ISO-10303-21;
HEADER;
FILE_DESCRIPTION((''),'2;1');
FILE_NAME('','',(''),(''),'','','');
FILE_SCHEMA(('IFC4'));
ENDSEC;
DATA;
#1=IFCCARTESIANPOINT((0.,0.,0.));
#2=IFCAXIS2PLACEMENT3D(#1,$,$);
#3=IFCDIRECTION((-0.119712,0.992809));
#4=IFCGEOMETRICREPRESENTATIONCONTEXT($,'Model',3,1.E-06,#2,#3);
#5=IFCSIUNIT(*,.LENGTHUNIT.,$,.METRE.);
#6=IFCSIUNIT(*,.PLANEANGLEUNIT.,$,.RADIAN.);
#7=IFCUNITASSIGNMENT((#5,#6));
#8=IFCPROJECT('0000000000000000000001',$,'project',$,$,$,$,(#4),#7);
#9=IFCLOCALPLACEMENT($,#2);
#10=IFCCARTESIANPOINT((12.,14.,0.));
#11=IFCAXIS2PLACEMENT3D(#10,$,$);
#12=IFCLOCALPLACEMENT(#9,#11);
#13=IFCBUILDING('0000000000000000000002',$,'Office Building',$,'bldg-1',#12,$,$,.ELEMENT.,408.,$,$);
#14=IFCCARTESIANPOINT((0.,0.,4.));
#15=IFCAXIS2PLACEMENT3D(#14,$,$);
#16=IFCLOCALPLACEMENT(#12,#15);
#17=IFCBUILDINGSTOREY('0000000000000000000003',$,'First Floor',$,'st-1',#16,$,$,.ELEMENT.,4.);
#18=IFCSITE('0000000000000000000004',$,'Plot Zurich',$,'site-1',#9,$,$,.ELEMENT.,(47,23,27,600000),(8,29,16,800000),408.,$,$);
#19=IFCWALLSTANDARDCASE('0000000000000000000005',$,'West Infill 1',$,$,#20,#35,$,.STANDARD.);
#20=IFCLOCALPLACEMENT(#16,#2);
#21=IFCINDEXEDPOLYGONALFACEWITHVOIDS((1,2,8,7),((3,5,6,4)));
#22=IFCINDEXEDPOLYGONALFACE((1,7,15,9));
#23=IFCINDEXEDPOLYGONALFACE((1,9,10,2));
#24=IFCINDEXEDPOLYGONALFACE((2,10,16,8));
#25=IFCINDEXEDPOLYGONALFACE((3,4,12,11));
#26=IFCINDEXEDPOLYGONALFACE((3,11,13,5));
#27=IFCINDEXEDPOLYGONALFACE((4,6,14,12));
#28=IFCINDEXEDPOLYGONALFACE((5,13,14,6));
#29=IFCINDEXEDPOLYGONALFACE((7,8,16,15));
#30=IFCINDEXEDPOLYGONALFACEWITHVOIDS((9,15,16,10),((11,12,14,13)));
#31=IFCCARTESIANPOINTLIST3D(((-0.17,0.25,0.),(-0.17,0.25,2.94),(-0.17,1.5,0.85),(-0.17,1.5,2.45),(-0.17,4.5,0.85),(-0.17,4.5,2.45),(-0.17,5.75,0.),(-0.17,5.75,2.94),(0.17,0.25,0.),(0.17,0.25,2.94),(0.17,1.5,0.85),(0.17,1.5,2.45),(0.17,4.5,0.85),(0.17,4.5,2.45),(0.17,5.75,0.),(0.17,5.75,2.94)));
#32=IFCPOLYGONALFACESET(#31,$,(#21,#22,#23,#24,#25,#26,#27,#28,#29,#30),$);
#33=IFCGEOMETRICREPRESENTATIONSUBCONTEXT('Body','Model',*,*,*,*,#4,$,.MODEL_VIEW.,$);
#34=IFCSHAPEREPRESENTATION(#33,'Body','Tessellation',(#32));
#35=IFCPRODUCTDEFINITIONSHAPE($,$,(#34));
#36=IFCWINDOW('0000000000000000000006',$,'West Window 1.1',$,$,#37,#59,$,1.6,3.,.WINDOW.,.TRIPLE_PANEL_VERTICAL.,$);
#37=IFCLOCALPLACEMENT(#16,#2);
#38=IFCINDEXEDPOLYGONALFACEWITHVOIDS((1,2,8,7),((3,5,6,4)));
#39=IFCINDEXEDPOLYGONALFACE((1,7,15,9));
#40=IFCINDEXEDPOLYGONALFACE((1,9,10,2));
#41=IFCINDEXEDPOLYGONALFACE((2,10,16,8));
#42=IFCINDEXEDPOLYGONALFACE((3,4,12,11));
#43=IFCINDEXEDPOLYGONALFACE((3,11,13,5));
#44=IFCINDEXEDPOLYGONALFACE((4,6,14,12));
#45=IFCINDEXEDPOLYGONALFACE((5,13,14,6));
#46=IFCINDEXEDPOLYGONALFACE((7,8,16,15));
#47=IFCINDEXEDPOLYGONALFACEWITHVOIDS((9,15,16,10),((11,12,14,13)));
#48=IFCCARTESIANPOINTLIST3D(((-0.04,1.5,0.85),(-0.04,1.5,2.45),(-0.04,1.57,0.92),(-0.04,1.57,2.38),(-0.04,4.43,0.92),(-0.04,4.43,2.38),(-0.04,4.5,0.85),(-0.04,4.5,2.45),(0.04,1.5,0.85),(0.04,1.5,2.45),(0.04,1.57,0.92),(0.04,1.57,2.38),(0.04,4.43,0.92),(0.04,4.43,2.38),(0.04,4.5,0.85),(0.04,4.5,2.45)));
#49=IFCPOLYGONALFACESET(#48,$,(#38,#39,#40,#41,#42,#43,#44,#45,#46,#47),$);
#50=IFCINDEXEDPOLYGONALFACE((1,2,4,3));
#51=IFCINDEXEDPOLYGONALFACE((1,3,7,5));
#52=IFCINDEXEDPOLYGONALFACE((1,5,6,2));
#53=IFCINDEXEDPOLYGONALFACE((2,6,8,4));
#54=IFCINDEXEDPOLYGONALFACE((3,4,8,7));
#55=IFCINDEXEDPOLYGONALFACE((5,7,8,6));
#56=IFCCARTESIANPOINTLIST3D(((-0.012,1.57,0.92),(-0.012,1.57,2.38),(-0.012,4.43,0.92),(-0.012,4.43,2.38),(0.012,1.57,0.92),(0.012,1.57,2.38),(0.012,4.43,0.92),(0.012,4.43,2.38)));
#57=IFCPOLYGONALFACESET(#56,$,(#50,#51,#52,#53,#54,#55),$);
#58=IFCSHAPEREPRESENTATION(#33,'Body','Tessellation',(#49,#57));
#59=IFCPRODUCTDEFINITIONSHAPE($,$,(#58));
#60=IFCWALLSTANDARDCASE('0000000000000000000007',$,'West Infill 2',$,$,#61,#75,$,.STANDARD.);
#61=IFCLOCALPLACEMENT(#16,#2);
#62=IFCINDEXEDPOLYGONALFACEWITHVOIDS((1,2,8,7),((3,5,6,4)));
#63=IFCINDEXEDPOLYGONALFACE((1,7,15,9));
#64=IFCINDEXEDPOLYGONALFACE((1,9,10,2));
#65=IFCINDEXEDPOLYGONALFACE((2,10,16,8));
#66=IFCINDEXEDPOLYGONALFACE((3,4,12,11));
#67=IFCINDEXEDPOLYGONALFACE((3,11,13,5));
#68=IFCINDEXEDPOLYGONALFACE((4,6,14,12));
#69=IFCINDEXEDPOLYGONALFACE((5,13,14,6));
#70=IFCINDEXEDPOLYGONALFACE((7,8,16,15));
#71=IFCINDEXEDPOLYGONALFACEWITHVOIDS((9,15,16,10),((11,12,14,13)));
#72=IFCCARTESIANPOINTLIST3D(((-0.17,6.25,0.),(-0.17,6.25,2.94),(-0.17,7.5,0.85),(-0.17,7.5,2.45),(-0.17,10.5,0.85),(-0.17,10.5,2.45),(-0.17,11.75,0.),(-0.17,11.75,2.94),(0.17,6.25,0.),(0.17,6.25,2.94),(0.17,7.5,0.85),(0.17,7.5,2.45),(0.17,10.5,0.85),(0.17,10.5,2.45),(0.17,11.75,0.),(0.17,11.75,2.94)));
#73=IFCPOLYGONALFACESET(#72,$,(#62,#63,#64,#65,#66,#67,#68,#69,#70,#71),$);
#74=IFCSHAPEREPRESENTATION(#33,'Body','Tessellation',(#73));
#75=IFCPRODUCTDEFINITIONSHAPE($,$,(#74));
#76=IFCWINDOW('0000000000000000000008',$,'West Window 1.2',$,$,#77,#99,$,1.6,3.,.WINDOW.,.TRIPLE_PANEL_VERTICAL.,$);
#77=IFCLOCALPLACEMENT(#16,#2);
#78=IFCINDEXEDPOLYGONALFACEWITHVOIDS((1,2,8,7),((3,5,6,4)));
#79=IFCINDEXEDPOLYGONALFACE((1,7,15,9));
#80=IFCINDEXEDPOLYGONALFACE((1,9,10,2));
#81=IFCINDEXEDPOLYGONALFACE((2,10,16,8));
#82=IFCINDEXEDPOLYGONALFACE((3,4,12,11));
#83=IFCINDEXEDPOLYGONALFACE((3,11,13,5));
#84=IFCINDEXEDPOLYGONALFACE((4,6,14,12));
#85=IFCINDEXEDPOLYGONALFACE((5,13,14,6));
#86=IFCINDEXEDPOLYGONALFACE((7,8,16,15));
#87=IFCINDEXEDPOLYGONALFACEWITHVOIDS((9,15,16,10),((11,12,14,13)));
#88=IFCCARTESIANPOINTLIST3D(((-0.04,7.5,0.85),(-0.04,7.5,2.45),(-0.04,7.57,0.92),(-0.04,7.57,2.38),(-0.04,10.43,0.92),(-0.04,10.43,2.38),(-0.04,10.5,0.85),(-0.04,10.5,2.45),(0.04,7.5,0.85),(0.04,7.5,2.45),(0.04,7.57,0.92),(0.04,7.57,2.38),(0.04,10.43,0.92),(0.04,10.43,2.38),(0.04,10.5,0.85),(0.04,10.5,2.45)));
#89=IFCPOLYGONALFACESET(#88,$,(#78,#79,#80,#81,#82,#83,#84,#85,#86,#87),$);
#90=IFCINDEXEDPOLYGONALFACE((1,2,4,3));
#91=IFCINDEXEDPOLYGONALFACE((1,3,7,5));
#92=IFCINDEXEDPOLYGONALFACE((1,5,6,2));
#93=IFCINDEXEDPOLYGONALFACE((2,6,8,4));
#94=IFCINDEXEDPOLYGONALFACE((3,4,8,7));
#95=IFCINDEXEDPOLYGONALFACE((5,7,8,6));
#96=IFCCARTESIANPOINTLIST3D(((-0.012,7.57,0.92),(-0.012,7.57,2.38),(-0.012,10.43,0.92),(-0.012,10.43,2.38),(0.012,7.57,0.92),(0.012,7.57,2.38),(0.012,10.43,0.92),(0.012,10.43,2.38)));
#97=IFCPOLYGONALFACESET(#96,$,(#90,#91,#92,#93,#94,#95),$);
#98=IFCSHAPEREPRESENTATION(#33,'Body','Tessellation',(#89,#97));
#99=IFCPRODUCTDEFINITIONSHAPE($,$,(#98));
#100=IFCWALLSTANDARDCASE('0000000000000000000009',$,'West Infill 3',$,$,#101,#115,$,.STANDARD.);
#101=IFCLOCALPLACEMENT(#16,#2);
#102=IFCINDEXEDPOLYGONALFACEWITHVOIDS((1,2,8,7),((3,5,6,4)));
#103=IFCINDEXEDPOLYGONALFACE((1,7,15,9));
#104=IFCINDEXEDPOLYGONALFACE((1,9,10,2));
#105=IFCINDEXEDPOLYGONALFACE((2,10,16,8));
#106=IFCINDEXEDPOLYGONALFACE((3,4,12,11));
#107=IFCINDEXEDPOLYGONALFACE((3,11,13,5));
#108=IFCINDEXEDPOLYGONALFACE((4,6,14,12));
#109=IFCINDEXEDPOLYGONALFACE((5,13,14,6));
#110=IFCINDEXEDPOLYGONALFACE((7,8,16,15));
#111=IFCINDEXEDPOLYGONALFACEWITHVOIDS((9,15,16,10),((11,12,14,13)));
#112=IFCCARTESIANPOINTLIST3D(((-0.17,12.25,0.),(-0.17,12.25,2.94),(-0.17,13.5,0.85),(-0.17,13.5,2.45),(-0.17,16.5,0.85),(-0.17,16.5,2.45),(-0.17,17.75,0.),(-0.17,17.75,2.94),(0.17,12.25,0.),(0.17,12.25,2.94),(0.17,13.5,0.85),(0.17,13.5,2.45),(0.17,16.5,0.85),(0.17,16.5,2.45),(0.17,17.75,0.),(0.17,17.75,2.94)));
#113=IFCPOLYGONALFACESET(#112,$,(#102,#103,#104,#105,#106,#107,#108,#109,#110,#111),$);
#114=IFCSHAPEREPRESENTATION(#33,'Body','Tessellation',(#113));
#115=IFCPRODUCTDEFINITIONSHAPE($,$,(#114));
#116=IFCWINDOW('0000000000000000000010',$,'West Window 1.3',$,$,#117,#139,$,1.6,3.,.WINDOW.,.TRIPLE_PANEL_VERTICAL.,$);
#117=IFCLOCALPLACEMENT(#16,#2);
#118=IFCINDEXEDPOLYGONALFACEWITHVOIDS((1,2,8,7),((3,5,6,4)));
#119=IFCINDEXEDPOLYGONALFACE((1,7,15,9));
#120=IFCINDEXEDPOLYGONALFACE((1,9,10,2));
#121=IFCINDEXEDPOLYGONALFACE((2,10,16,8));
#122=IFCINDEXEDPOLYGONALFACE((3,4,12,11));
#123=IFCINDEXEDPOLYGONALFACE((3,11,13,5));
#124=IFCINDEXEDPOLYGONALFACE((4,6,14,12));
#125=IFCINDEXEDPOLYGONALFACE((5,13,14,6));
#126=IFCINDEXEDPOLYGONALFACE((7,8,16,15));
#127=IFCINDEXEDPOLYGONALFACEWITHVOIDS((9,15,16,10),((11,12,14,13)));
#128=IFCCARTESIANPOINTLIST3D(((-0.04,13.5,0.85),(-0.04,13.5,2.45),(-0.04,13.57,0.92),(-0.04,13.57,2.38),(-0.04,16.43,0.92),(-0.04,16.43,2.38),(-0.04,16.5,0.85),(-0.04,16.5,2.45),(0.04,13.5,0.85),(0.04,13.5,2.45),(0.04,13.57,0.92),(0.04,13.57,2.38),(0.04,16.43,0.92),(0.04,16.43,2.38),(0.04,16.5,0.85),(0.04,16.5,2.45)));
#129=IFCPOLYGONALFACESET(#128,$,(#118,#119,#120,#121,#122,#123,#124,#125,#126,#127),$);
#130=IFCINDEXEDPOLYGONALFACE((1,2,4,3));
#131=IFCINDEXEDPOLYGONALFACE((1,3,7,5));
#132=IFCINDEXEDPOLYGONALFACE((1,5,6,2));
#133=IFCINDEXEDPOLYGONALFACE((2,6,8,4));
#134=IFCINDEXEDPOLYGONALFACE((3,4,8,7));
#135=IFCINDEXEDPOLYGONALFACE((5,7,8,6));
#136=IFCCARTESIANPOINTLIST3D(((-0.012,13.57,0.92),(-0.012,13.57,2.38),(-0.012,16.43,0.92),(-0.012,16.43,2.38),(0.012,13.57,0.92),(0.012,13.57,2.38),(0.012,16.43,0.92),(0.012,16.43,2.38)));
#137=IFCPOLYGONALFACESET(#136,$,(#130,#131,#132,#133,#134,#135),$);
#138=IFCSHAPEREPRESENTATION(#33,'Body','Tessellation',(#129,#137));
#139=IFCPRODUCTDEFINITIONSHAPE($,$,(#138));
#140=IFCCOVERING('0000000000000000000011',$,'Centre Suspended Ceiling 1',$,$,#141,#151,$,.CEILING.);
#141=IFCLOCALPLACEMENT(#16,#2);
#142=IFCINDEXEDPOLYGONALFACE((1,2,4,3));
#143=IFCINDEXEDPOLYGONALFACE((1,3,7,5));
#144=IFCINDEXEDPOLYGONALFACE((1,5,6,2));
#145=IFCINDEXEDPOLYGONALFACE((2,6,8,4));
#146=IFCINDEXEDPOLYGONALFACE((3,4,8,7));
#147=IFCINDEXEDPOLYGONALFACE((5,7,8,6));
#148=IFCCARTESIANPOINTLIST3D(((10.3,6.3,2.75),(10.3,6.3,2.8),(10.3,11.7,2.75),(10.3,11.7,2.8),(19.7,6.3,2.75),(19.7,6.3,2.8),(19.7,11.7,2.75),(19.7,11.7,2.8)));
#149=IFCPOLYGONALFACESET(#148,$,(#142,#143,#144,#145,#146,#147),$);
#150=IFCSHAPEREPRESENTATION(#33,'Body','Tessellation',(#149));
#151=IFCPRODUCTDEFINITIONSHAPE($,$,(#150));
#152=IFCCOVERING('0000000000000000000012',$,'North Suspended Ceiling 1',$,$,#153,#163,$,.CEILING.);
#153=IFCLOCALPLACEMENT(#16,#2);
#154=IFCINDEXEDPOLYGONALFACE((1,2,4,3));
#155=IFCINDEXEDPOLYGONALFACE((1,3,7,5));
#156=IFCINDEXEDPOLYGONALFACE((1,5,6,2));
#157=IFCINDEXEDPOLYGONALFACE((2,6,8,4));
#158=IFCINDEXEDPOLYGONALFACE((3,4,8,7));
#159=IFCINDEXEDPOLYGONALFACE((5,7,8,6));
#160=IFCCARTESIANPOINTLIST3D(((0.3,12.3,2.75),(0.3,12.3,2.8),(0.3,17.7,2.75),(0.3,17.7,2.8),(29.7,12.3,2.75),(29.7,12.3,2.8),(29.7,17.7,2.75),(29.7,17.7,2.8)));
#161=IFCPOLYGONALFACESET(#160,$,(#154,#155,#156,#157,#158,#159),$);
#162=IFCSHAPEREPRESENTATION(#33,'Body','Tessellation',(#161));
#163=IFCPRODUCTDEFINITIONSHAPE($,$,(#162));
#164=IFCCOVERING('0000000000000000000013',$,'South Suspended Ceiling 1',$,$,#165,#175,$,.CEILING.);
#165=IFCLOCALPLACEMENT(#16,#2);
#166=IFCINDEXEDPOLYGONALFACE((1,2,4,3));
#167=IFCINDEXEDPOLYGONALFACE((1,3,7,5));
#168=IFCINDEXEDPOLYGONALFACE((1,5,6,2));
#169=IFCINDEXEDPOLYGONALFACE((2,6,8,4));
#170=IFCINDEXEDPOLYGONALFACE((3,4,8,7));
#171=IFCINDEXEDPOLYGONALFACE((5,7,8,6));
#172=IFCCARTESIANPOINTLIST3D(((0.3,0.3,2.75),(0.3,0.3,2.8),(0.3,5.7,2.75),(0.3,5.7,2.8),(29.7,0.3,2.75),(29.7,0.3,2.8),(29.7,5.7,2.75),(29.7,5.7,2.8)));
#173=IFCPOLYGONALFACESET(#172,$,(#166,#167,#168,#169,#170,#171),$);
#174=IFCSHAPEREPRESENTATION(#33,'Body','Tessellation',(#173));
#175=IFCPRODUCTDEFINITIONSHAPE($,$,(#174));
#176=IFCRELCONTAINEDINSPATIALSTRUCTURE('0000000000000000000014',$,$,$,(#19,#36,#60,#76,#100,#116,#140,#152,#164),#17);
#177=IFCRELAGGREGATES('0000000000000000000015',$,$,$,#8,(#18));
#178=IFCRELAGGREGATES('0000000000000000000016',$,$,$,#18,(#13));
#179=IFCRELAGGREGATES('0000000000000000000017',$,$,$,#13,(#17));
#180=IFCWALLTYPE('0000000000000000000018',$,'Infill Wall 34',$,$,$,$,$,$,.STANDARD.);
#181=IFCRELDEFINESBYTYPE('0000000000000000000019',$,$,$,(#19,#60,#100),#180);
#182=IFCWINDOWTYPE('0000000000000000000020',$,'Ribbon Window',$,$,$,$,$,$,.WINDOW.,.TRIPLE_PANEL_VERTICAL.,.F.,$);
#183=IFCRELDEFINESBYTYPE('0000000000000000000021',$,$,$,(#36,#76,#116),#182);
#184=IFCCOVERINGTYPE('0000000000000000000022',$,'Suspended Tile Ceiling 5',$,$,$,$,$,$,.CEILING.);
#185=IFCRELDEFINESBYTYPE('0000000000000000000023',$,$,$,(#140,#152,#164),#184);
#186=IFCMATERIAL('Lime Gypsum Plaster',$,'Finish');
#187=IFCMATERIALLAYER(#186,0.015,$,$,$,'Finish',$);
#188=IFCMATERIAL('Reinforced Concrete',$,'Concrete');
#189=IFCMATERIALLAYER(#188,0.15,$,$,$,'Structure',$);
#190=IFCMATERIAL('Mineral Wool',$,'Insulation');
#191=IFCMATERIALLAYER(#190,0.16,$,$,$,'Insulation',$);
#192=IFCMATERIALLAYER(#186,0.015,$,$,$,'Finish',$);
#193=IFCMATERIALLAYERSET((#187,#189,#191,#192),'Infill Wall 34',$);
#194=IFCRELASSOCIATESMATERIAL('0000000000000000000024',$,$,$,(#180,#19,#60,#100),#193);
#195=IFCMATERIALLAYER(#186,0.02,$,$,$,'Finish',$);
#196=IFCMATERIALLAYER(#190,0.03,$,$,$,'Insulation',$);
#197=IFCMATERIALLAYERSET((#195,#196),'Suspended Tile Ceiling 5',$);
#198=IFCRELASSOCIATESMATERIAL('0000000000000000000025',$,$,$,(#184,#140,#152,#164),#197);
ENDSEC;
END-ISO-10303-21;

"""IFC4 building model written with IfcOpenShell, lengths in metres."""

from ifc_helpers import new_model, si_unit, direction, frame, frame_2d, origin, origin_2d, place, context, subcontext, project, spatial, polyline, rectangle, outline, extrude, material, layer, layer_set, layer_usage, type_object, element, fill, save


model = new_model("IFC4")

# Units and contexts
model_context = context("Model", 3, precision=1e-06, world=origin(), true_north=direction((-0.119712, 0.992809)))
body_context = subcontext(model_context, "Body", "Model", "MODEL_VIEW")
ifc_project = project(units=[si_unit("LENGTHUNIT", "METRE"), si_unit("PLANEANGLEUNIT", "RADIAN")], contexts=[model_context])

# Site, building, storey
site_placement = place(None, origin())
site = spatial("IfcSite", under=ifc_project, at=site_placement, Name="Plot Zurich", ObjectType="site-1", CompositionType="ELEMENT", RefLatitude=(47, 23, 27, 600000), RefLongitude=(8, 29, 16, 800000), RefElevation=408.0)
building_placement = place(site_placement, frame((12.0, 14.0, 0.0)))
building = spatial("IfcBuilding", under=site, at=building_placement, Name="Office Building", ObjectType="bldg-1", CompositionType="ELEMENT", ElevationOfRefHeight=408.0)
storey_placement = place(building_placement, frame((0.0, 0.0, 4.0)))
storey = spatial("IfcBuildingStorey", under=building, at=storey_placement, Name="First Floor", ObjectType="st-1", CompositionType="ELEMENT", Elevation=4.0)

# Shared definitions
ifc_material_1 = material(Name="Reinforced Concrete", Category="Concrete")

# Walls, openings, windows
ifc_material_2 = material(Name="Lime Gypsum Plaster", Category="Finish")
ifc_layer_1 = layer(ifc_material_2, 0.015, Category="Finish")
ifc_layer_2 = layer(ifc_material_1, 0.15, Category="Structure")
ifc_material_3 = material(Name="Mineral Wool", Category="Insulation")
ifc_layer_3 = layer(ifc_material_3, 0.16, Category="Insulation")
ifc_layer_4 = layer(ifc_material_2, 0.015, Category="Finish")
ifc_layer_set_1 = layer_set([ifc_layer_1, ifc_layer_2, ifc_layer_3, ifc_layer_4], Name="Infill Wall 34")
ifc_layer_usage_1 = layer_usage(ifc_layer_set_1, "AXIS2", "NEGATIVE", 0.17)
wall_type_1 = type_object("IfcWallType", Name="Infill Wall 34", PredefinedType="STANDARD", material=ifc_layer_set_1)
wall_1_placement = place(storey_placement, frame((0.0, 5.75, 0.0), z_axis=(0.0, 0.0, 1.0), x_axis=(0.0, -1.0, 0.0)))
wall_1 = element("IfcWallStandardCase", 1, at=wall_1_placement, inside=storey, type_object=wall_type_1, material=ifc_layer_usage_1, Name="West Infill 1", PredefinedType="STANDARD", context=body_context, shape_type="SweptSolid", body=[
    extrude(rectangle(XDim=5.5, YDim=0.34, at=frame_2d((2.75, 0.0))), origin(), (0.0, 0.0, 1.0), 2.94),
])
opening_1_placement = place(wall_1_placement, frame((2.75, 0.0, 0.85)))
opening_1 = element("IfcOpeningElement", 2, at=opening_1_placement, cuts=wall_1, PredefinedType="OPENING", context=body_context, shape_type="SweptSolid", body=[
    extrude(rectangle(XDim=3.0, YDim=0.34, at=origin_2d()), origin(), (0.0, 0.0, 1.0), 1.6),
])
window_type = type_object("IfcWindowType", Name="Ribbon Window", ParameterTakesPrecedence=False, PartitioningType="TRIPLE_PANEL_VERTICAL", PredefinedType="WINDOW")
window_1_placement = place(opening_1_placement, frame((0.0, 0.0, 0.0), z_axis=(0.0, -1.0, 0.0), x_axis=(1.0, 0.0, 0.0)))
window_1 = element("IfcWindow", 3, at=window_1_placement, inside=storey, type_object=window_type, Name="West Window 1.1", OverallHeight=1.6, OverallWidth=3.0, PartitioningType="TRIPLE_PANEL_VERTICAL", PredefinedType="WINDOW", context=body_context, shape_type="SweptSolid", body=[
    extrude(outline(polyline([(-1.5, 0.0), (1.5, 0.0), (1.5, 1.6), (-1.5, 1.6), (-1.5, 0.0)]), holes=[polyline([(-1.43, 0.07), (1.43, 0.07), (1.43, 1.53), (-1.43, 1.53), (-1.43, 0.07)])]), frame((0.0, 0.0, -0.04)), (0.0, 0.0, 1.0), 0.08),
    extrude(rectangle(XDim=2.86, YDim=1.46, at=frame_2d((0.0, 0.8))), frame((0.0, 0.0, -0.012)), (0.0, 0.0, 1.0), 0.024),
])
fill(opening_1, window_1)
ifc_layer_usage_2 = layer_usage(ifc_layer_set_1, "AXIS2", "NEGATIVE", 0.17)
wall_2_placement = place(storey_placement, frame((0.0, 11.75, 0.0), z_axis=(0.0, 0.0, 1.0), x_axis=(0.0, -1.0, 0.0)))
wall_2 = element("IfcWallStandardCase", 4, at=wall_2_placement, inside=storey, type_object=wall_type_1, material=ifc_layer_usage_2, Name="West Infill 2", PredefinedType="STANDARD", context=body_context, shape_type="SweptSolid", body=[
    extrude(rectangle(XDim=5.5, YDim=0.34, at=frame_2d((2.75, 0.0))), origin(), (0.0, 0.0, 1.0), 2.94),
])
opening_2_placement = place(wall_2_placement, frame((2.75, 0.0, 0.85)))
opening_2 = element("IfcOpeningElement", 5, at=opening_2_placement, cuts=wall_2, PredefinedType="OPENING", context=body_context, shape_type="SweptSolid", body=[
    extrude(rectangle(XDim=3.0, YDim=0.34, at=origin_2d()), origin(), (0.0, 0.0, 1.0), 1.6),
])
window_2_placement = place(opening_2_placement, frame((0.0, 0.0, 0.0), z_axis=(0.0, -1.0, 0.0), x_axis=(1.0, 0.0, 0.0)))
window_2 = element("IfcWindow", 6, at=window_2_placement, inside=storey, type_object=window_type, Name="West Window 1.2", OverallHeight=1.6, OverallWidth=3.0, PartitioningType="TRIPLE_PANEL_VERTICAL", PredefinedType="WINDOW", context=body_context, shape_type="SweptSolid", body=[
    extrude(outline(polyline([(-1.5, 0.0), (1.5, 0.0), (1.5, 1.6), (-1.5, 1.6), (-1.5, 0.0)]), holes=[polyline([(-1.43, 0.07), (1.43, 0.07), (1.43, 1.53), (-1.43, 1.53), (-1.43, 0.07)])]), frame((0.0, 0.0, -0.04)), (0.0, 0.0, 1.0), 0.08),
    extrude(rectangle(XDim=2.86, YDim=1.46, at=frame_2d((0.0, 0.8))), frame((0.0, 0.0, -0.012)), (0.0, 0.0, 1.0), 0.024),
])
fill(opening_2, window_2)
ifc_layer_usage_3 = layer_usage(ifc_layer_set_1, "AXIS2", "NEGATIVE", 0.17)
wall_3_placement = place(storey_placement, frame((0.0, 17.75, 0.0), z_axis=(0.0, 0.0, 1.0), x_axis=(0.0, -1.0, 0.0)))
wall_3 = element("IfcWallStandardCase", 7, at=wall_3_placement, inside=storey, type_object=wall_type_1, material=ifc_layer_usage_3, Name="West Infill 3", PredefinedType="STANDARD", context=body_context, shape_type="SweptSolid", body=[
    extrude(rectangle(XDim=5.5, YDim=0.34, at=frame_2d((2.75, 0.0))), origin(), (0.0, 0.0, 1.0), 2.94),
])
opening_3_placement = place(wall_3_placement, frame((2.75, 0.0, 0.85)))
opening_3 = element("IfcOpeningElement", 8, at=opening_3_placement, cuts=wall_3, PredefinedType="OPENING", context=body_context, shape_type="SweptSolid", body=[
    extrude(rectangle(XDim=3.0, YDim=0.34, at=origin_2d()), origin(), (0.0, 0.0, 1.0), 1.6),
])
window_3_placement = place(opening_3_placement, frame((0.0, 0.0, 0.0), z_axis=(0.0, -1.0, 0.0), x_axis=(1.0, 0.0, 0.0)))
window_3 = element("IfcWindow", 9, at=window_3_placement, inside=storey, type_object=window_type, Name="West Window 1.3", OverallHeight=1.6, OverallWidth=3.0, PartitioningType="TRIPLE_PANEL_VERTICAL", PredefinedType="WINDOW", context=body_context, shape_type="SweptSolid", body=[
    extrude(outline(polyline([(-1.5, 0.0), (1.5, 0.0), (1.5, 1.6), (-1.5, 1.6), (-1.5, 0.0)]), holes=[polyline([(-1.43, 0.07), (1.43, 0.07), (1.43, 1.53), (-1.43, 1.53), (-1.43, 0.07)])]), frame((0.0, 0.0, -0.04)), (0.0, 0.0, 1.0), 0.08),
    extrude(rectangle(XDim=2.86, YDim=1.46, at=frame_2d((0.0, 0.8))), frame((0.0, 0.0, -0.012)), (0.0, 0.0, 1.0), 0.024),
])
fill(opening_3, window_3)

# Coverings
ifc_layer_5 = layer(ifc_material_2, 0.02, Category="Finish")
ifc_layer_6 = layer(ifc_material_3, 0.03, Category="Insulation")
ifc_layer_set_2 = layer_set([ifc_layer_5, ifc_layer_6], Name="Suspended Tile Ceiling 5")
ifc_layer_usage_4 = layer_usage(ifc_layer_set_2, "AXIS3", "NEGATIVE", 0.05)
covering_type = type_object("IfcCoveringType", Name="Suspended Tile Ceiling 5", PredefinedType="CEILING", material=ifc_layer_set_2)
covering_1_placement = place(storey_placement, frame((0.0, 0.0, 2.75)))
element("IfcCovering", 10, at=covering_1_placement, inside=storey, type_object=covering_type, material=ifc_layer_usage_4, Name="Centre Suspended Ceiling 1", PredefinedType="CEILING", context=body_context, shape_type="SweptSolid", body=[
    extrude(outline(polyline([(10.3, 6.3), (19.7, 6.3), (19.7, 11.7), (10.3, 11.7), (10.3, 6.3)])), origin(), (0.0, 0.0, 1.0), 0.05),
])
ifc_layer_usage_5 = layer_usage(ifc_layer_set_2, "AXIS3", "NEGATIVE", 0.05)
covering_2_placement = place(storey_placement, frame((0.0, 0.0, 2.75)))
element("IfcCovering", 11, at=covering_2_placement, inside=storey, type_object=covering_type, material=ifc_layer_usage_5, Name="North Suspended Ceiling 1", PredefinedType="CEILING", context=body_context, shape_type="SweptSolid", body=[
    extrude(outline(polyline([(0.3, 12.3), (29.7, 12.3), (29.7, 17.7), (0.3, 17.7), (0.3, 12.3)])), origin(), (0.0, 0.0, 1.0), 0.05),
])
ifc_layer_usage_6 = layer_usage(ifc_layer_set_2, "AXIS3", "NEGATIVE", 0.05)
covering_3_placement = place(storey_placement, frame((0.0, 0.0, 2.75)))
element("IfcCovering", 12, at=covering_3_placement, inside=storey, type_object=covering_type, material=ifc_layer_usage_6, Name="South Suspended Ceiling 1", PredefinedType="CEILING", context=body_context, shape_type="SweptSolid", body=[
    extrude(outline(polyline([(0.3, 0.3), (29.7, 0.3), (29.7, 5.7), (0.3, 5.7), (0.3, 0.3)])), origin(), (0.0, 0.0, 1.0), 0.05),
])

save(model, "model.ifc")
